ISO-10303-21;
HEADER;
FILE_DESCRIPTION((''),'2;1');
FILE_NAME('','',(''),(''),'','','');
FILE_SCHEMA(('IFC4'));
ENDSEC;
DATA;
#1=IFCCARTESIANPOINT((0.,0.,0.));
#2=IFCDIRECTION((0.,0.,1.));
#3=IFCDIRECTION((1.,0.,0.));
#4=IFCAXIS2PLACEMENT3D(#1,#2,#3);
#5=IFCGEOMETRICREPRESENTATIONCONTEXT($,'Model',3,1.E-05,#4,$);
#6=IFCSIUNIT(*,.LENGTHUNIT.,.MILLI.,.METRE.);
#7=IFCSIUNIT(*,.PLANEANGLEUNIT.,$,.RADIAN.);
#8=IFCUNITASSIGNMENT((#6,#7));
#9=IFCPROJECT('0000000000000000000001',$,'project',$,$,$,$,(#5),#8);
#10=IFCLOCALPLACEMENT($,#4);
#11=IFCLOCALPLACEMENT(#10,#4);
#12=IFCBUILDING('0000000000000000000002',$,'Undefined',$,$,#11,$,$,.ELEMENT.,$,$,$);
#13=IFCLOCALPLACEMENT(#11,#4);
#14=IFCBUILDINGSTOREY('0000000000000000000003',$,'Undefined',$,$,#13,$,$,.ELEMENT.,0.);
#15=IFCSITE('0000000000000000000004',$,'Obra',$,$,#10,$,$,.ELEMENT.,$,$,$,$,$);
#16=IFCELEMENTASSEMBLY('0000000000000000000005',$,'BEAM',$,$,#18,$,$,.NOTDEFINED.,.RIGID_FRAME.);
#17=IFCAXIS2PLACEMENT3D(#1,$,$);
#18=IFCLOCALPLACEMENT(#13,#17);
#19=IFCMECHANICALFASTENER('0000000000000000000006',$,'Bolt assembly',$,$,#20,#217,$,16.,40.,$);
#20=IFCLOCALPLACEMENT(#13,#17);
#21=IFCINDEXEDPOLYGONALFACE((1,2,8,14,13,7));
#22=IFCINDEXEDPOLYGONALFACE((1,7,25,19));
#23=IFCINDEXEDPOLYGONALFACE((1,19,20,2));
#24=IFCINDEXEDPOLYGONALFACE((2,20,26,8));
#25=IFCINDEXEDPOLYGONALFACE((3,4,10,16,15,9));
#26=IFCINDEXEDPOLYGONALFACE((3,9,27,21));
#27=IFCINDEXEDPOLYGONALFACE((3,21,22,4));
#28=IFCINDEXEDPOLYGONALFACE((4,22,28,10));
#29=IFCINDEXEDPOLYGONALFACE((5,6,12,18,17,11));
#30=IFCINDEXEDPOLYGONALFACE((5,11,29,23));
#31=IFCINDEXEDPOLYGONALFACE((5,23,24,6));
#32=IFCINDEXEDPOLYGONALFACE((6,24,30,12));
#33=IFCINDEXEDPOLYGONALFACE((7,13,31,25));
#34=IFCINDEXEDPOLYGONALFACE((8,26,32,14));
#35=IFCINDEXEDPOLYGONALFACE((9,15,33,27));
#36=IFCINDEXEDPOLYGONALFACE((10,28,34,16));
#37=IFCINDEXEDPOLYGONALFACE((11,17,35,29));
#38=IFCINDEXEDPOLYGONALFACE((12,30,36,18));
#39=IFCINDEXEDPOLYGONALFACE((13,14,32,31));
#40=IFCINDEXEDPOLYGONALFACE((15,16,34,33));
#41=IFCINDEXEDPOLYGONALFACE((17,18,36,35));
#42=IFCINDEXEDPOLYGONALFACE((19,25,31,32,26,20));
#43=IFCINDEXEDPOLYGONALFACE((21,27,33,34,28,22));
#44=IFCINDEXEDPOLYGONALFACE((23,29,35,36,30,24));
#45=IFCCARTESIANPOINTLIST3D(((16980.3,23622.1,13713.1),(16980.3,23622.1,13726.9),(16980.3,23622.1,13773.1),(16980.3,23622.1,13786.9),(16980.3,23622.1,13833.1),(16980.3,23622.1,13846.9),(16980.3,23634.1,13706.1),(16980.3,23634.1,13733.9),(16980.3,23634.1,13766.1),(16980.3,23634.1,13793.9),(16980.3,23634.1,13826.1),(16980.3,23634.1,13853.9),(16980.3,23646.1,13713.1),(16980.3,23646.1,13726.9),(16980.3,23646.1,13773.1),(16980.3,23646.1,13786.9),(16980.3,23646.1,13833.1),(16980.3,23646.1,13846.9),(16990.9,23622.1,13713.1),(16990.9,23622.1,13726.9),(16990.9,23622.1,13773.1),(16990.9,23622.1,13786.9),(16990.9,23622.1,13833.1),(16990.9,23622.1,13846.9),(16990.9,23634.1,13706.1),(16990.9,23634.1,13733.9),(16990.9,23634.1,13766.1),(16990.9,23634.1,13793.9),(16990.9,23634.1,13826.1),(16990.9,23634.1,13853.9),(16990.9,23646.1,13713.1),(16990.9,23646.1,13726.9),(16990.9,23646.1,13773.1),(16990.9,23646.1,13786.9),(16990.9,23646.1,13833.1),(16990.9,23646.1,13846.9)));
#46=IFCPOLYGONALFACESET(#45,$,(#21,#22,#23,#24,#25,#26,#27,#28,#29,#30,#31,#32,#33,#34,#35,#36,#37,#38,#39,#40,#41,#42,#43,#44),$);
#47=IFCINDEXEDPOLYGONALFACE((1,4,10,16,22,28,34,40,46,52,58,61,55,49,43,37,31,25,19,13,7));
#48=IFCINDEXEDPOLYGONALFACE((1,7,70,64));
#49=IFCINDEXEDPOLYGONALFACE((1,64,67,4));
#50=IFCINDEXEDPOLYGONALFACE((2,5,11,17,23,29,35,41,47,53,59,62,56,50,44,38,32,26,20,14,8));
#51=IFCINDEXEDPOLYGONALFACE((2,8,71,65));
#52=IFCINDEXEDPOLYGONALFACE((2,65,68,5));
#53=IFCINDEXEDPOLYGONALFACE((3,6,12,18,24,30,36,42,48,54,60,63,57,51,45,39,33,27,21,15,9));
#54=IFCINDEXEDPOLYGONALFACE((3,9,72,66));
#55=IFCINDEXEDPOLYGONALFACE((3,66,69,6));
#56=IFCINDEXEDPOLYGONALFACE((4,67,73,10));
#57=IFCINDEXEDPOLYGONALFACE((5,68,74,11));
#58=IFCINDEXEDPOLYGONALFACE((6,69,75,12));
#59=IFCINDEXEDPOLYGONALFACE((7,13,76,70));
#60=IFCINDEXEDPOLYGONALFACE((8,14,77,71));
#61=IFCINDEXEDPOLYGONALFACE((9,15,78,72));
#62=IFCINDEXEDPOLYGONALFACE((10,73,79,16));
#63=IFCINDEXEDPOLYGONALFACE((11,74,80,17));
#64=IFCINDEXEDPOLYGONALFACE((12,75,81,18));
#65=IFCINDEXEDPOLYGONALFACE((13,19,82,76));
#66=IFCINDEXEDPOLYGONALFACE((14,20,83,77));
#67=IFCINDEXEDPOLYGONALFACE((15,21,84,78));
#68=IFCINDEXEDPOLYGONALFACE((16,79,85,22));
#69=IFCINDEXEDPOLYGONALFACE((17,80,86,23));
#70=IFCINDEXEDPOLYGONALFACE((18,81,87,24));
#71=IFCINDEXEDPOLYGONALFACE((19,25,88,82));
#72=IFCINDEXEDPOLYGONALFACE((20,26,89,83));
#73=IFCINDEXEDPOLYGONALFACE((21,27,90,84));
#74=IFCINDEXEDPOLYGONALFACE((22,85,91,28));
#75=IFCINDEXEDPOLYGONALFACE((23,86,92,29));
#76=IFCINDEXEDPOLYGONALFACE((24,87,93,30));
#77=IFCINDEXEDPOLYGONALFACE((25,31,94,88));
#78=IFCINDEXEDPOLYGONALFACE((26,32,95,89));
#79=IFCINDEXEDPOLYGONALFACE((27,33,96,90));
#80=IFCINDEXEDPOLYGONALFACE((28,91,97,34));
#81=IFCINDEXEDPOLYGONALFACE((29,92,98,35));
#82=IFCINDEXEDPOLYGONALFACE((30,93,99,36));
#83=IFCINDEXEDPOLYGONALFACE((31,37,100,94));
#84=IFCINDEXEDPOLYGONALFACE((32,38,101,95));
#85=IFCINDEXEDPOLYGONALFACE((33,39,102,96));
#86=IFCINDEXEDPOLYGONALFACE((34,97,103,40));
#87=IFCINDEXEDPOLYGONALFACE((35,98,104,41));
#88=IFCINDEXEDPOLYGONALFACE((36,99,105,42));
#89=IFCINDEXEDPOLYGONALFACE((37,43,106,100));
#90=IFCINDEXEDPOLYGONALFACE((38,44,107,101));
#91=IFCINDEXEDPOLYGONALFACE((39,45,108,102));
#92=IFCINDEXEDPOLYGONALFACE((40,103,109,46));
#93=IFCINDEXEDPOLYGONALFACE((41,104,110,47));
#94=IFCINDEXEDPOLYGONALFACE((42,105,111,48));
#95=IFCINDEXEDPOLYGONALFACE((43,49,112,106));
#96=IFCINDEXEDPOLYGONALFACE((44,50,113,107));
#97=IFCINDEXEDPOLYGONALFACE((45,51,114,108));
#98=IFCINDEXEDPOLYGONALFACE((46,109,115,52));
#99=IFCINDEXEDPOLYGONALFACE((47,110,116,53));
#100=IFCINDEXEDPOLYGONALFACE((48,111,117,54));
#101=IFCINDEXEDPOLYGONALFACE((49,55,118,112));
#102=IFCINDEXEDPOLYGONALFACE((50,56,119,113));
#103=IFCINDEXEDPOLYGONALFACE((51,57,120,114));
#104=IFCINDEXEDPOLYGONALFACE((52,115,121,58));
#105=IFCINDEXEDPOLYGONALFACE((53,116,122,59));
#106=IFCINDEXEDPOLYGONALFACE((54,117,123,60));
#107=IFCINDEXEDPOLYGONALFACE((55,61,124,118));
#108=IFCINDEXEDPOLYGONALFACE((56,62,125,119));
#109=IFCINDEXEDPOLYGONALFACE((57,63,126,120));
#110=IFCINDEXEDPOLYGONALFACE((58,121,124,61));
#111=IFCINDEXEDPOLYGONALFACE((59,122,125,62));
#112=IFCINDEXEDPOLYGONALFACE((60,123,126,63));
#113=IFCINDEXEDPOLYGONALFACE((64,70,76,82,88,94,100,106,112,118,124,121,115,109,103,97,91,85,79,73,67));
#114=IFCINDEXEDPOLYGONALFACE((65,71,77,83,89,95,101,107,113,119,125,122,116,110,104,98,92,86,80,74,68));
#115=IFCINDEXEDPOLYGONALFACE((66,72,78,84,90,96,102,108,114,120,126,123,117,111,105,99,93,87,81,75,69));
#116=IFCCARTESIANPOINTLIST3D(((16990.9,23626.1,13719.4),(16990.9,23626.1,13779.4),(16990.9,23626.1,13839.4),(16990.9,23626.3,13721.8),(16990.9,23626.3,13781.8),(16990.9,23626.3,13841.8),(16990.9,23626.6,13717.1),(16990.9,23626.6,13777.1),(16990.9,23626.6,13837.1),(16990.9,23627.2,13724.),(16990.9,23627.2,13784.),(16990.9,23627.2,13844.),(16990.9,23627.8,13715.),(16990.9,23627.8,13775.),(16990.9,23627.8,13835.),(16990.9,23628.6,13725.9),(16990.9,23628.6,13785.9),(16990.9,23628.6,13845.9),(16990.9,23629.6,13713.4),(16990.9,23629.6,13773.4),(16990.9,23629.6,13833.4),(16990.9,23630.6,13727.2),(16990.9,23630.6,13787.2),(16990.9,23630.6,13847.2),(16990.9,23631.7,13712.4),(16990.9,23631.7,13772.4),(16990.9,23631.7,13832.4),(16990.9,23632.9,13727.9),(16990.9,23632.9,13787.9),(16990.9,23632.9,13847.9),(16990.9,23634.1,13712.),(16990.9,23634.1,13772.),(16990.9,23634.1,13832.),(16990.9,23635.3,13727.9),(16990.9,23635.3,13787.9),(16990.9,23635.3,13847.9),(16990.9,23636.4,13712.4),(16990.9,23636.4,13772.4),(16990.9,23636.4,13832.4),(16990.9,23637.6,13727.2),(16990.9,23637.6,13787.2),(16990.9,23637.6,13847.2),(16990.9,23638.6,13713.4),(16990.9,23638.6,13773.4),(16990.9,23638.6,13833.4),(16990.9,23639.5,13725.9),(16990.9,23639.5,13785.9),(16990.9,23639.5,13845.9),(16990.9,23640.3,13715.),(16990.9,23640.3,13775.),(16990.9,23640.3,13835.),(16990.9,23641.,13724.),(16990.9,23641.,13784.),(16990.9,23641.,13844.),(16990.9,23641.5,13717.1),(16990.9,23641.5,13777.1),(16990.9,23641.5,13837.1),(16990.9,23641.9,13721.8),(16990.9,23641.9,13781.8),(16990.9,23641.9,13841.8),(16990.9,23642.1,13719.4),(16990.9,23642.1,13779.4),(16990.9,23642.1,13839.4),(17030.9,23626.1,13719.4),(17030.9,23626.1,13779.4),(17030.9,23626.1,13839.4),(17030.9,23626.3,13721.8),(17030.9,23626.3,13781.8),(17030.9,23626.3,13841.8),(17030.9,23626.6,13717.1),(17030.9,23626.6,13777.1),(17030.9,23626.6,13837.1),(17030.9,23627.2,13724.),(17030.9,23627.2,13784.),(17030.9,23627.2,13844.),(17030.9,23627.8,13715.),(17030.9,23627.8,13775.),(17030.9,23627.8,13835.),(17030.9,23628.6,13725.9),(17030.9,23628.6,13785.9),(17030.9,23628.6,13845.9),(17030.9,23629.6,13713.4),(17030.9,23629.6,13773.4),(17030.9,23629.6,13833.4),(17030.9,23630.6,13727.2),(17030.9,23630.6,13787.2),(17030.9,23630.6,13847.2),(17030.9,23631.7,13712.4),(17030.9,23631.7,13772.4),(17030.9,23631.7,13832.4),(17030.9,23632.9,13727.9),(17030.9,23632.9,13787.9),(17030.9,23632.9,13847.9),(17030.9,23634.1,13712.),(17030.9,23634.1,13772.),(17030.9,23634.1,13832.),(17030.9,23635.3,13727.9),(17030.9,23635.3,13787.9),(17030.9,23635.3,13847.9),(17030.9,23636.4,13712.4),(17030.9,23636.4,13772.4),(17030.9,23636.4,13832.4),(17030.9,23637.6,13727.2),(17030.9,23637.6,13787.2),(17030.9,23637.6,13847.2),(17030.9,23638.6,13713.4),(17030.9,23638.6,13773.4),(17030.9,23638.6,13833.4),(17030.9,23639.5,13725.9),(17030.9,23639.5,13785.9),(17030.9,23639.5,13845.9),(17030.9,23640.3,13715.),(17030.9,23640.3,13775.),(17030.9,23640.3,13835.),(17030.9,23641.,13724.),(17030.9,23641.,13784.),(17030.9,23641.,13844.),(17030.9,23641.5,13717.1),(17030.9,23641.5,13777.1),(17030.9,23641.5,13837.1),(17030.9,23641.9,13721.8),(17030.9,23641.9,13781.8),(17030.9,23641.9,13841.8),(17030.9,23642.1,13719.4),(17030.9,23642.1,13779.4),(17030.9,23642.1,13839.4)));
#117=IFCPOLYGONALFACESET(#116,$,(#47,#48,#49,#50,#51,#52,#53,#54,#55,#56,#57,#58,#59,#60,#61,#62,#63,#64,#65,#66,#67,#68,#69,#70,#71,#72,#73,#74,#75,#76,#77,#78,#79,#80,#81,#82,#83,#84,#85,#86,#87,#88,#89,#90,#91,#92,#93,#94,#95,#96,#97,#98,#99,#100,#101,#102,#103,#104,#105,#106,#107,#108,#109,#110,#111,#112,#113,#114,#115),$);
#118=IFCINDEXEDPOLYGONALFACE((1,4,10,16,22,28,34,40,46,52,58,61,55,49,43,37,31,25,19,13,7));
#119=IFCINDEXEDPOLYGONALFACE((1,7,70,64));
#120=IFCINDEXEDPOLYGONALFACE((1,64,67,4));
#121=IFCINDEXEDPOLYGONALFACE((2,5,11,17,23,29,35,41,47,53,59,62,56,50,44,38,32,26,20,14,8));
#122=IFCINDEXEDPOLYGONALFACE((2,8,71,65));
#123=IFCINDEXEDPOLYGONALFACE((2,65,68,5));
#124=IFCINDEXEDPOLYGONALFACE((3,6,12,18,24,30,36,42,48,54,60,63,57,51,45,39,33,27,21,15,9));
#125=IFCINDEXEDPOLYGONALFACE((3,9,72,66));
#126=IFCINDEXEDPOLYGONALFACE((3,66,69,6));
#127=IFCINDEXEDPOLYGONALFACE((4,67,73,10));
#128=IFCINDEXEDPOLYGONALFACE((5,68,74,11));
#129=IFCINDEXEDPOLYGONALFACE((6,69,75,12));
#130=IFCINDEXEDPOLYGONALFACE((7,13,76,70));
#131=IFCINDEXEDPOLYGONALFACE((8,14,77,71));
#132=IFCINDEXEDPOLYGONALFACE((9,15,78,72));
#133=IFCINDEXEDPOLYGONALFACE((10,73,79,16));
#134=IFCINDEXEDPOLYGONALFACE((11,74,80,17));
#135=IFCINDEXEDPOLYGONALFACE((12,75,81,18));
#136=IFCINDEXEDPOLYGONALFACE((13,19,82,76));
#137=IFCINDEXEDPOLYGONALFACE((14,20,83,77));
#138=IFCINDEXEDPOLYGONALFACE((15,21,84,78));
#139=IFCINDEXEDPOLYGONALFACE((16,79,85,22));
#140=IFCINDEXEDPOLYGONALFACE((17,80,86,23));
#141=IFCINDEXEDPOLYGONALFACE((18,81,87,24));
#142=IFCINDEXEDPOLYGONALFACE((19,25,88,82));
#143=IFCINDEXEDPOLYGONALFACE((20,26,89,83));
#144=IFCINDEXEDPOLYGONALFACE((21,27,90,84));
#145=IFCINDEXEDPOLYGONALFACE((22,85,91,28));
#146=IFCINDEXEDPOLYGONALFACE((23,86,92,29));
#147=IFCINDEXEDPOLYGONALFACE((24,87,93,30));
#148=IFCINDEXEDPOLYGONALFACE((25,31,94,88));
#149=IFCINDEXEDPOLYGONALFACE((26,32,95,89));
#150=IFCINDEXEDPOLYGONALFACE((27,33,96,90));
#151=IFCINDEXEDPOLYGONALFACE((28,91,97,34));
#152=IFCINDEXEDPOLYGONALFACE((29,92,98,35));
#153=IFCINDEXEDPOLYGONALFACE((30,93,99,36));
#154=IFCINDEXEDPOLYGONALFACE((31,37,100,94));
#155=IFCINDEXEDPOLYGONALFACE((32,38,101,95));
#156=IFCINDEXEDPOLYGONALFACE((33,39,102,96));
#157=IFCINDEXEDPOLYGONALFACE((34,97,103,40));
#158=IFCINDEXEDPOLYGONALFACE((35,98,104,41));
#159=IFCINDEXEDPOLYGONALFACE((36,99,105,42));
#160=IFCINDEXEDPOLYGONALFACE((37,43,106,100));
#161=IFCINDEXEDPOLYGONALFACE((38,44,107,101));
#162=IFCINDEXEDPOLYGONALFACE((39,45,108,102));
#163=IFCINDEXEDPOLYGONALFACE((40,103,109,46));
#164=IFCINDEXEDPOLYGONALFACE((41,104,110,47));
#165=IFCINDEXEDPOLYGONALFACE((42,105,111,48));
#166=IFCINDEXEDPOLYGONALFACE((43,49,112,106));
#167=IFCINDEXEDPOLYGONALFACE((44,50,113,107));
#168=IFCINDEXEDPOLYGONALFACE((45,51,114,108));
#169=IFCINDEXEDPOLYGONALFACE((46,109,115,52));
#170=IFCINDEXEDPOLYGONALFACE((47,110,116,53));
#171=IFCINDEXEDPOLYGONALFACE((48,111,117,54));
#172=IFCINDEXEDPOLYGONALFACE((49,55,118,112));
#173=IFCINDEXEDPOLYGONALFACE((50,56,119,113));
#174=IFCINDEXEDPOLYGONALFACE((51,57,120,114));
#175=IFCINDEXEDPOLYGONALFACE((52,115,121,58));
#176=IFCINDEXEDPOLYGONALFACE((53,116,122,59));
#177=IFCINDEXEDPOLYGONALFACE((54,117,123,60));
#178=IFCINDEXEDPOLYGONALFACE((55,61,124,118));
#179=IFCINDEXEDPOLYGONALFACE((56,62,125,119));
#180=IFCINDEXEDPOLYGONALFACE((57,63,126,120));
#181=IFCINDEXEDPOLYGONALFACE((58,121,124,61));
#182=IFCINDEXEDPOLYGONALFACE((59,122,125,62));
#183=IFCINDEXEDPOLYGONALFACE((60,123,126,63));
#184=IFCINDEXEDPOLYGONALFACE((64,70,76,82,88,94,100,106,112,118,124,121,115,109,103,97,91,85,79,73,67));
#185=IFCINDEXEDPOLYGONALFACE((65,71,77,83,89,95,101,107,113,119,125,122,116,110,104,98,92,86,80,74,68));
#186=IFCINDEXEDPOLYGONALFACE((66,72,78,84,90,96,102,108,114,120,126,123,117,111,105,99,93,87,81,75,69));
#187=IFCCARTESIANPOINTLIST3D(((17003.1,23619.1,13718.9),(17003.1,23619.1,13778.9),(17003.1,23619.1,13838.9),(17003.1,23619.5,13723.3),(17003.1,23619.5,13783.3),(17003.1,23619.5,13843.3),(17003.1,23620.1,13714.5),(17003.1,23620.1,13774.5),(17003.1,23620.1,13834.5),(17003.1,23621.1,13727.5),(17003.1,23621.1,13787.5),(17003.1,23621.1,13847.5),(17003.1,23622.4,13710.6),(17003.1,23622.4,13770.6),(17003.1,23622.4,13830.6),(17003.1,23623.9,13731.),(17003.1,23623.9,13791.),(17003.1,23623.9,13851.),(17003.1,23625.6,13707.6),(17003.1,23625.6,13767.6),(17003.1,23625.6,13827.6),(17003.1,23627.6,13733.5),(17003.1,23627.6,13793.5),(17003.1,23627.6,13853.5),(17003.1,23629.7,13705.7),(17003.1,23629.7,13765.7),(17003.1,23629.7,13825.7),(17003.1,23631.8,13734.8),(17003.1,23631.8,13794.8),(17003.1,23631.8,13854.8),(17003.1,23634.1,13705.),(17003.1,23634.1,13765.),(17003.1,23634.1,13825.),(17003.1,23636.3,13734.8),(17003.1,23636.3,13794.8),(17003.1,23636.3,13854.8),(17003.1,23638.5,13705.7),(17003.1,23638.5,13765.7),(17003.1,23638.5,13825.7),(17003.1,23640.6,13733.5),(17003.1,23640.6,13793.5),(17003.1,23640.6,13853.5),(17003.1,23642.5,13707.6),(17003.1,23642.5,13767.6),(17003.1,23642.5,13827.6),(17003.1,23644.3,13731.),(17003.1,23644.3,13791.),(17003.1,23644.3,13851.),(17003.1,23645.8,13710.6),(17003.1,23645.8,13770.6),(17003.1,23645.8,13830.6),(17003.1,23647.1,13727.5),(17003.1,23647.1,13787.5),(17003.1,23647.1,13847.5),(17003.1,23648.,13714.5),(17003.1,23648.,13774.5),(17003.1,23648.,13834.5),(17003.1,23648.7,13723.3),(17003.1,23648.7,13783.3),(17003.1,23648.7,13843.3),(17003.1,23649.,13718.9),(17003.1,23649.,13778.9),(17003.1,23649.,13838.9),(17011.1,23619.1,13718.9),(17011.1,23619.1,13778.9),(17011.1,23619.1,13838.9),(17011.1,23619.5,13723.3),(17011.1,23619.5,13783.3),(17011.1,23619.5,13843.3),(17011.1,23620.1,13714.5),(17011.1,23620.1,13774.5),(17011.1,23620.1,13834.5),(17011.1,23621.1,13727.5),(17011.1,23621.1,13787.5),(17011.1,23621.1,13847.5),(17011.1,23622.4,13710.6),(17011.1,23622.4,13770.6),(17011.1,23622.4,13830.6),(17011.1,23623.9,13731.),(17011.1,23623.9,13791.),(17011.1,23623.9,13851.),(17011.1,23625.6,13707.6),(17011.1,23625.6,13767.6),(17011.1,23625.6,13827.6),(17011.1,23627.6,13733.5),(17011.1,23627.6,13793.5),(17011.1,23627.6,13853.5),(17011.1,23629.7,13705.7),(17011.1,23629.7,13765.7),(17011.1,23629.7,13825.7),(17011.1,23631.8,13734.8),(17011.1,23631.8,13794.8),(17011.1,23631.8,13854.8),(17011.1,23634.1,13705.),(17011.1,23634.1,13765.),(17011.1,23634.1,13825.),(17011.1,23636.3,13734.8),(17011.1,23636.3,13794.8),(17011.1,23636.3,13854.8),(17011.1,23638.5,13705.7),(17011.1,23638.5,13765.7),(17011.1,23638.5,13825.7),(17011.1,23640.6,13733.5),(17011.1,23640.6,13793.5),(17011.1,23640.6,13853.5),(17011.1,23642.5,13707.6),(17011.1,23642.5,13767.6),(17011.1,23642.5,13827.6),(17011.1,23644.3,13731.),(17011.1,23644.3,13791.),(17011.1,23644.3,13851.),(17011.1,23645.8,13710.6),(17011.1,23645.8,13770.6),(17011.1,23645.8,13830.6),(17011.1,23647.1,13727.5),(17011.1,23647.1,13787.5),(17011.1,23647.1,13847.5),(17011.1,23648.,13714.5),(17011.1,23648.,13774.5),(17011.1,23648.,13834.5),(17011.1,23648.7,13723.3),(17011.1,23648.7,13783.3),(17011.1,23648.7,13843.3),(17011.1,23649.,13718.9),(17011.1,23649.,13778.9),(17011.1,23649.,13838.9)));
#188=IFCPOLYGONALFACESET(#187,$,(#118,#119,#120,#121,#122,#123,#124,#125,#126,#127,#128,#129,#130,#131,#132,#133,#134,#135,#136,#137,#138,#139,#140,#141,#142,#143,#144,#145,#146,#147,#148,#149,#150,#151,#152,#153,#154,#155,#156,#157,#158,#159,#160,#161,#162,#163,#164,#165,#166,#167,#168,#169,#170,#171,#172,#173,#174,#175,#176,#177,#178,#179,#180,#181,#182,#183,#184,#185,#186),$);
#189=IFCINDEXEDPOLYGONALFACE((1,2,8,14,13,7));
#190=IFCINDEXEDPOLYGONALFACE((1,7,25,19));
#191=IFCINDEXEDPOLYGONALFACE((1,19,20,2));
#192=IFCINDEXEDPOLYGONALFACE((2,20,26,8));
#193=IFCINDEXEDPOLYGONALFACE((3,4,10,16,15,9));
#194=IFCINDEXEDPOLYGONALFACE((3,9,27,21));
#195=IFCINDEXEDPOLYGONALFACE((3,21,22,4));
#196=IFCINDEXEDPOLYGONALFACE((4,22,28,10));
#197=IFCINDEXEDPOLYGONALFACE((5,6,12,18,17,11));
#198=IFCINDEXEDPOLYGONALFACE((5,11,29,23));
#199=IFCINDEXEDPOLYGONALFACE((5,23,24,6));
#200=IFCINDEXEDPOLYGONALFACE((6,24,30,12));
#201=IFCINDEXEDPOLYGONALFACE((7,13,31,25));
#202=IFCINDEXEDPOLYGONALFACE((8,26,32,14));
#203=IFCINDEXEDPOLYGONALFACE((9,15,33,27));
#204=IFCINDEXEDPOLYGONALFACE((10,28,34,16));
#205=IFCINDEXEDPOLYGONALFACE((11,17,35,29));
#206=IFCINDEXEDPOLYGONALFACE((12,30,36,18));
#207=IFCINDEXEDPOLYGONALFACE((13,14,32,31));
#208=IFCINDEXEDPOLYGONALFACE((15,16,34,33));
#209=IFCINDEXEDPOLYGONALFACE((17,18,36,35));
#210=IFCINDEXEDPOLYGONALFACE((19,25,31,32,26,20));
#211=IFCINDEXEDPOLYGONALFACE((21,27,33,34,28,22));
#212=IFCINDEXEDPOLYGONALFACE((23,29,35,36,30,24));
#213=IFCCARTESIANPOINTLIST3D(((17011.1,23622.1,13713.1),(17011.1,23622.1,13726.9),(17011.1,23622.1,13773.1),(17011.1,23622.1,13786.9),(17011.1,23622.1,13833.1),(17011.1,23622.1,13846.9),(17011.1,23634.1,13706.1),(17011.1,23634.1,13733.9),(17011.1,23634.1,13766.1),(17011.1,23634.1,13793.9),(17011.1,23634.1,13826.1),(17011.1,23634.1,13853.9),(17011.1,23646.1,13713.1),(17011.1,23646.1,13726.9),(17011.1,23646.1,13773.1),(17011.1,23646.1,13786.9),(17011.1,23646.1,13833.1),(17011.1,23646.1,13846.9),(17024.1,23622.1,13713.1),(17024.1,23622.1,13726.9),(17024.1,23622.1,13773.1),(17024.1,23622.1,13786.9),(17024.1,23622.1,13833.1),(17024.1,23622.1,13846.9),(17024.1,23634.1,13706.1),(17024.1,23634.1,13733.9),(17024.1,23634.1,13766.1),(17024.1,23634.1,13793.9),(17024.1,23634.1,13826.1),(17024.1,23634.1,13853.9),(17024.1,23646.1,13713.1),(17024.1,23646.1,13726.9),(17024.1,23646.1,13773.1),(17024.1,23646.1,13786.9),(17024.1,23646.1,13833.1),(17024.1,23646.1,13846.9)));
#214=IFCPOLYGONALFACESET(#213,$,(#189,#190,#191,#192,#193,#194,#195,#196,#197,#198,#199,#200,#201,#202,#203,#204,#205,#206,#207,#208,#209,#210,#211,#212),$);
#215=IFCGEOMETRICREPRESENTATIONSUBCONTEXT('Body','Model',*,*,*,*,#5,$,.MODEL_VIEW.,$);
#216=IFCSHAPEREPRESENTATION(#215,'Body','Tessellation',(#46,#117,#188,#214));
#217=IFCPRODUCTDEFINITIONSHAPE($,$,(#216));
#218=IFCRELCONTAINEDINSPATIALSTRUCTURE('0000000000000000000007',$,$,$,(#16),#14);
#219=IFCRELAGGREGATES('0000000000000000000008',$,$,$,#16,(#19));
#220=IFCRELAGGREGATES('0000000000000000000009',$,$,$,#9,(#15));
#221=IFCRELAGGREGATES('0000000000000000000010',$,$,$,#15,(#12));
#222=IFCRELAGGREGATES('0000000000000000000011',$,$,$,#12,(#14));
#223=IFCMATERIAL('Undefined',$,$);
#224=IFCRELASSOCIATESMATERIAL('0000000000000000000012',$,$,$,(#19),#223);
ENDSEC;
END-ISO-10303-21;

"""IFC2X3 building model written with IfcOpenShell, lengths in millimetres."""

from ifc_helpers import new_model, si_unit, frame, origin_with_axes, origin_2d_with_axis, place, context, subcontext, project, spatial, polyline, circle, outline, extrude, source, transform, mapped, material, element, aggregate, save


model = new_model("IFC2X3")

# Units and contexts
model_context = context("Model", 3, precision=1e-05, world=origin_with_axes())
body_context = subcontext(model_context, "Body", "Model", "MODEL_VIEW")
ifc_project = project(units=[si_unit("LENGTHUNIT", "METRE", prefix="MILLI"), si_unit("PLANEANGLEUNIT", "RADIAN")], contexts=[model_context])

# Site, building, storey
site_placement = place(None, origin_with_axes())
site = spatial("IfcSite", under=ifc_project, at=site_placement, Name="Obra", CompositionType="ELEMENT")
building_placement = place(site_placement, origin_with_axes())
building = spatial("IfcBuilding", under=site, at=building_placement, Name="Undefined", CompositionType="ELEMENT")
storey_placement = place(building_placement, origin_with_axes())
storey = spatial("IfcBuildingStorey", under=building, at=storey_placement, Name="Undefined", CompositionType="ELEMENT", Elevation=0.0)

# Shared definitions
ifc_material_1 = material(Name="Undefined")

# Element assembly, mechanical fastener
assembly_1_placement = place(storey_placement, origin_with_axes())
assembly_1 = element("IfcElementAssembly", 1, at=assembly_1_placement, inside=storey, Name="BEAM", AssemblyPlace="NOTDEFINED", PredefinedType="RIGID_FRAME")
shared_shape_1 = source(origin_with_axes(), body_context, "Body", "SweptSolid", [
    extrude(outline(polyline([(13.9, 0.0), (6.9, 12.0), (-6.9, 12.0), (-13.9, 0.0), (-6.9, -12.0), (6.9, -12.0), (13.9, 0.0)])), frame((0.0, -19.7, 0.0), z_axis=(0.0, 1.0, 0.0), x_axis=(1.0, 0.0, 0.0)), (0.0, 0.0, 1.0), 10.6),
    extrude(circle(Radius=8.0, at=origin_2d_with_axis()), frame((0.0, -9.1, 0.0), z_axis=(0.0, 1.0, 0.0), x_axis=(1.0, 0.0, 0.0)), (0.0, 0.0, 1.0), 40.0),
    extrude(circle(Radius=15.0, at=origin_2d_with_axis()), frame((0.0, 3.1, 0.0), z_axis=(0.0, 1.0, 0.0), x_axis=(1.0, 0.0, 0.0)), (0.0, 0.0, 1.0), 8.0),
    extrude(outline(polyline([(13.9, 0.0), (6.9, 12.0), (-6.9, 12.0), (-13.9, 0.0), (-6.9, -12.0), (6.9, -12.0), (13.9, 0.0)])), frame((0.0, 11.1, 0.0), z_axis=(0.0, 1.0, 0.0), x_axis=(1.0, 0.0, 0.0)), (0.0, 0.0, 1.0), 13.0),
])
mechanical_fastener_1_placement = place(assembly_1_placement, frame((17000.0, 23684.1, 13900.0), z_axis=(0.0, -1.0, 0.0), x_axis=(0.0, 0.0, -1.0)))
mechanical_fastener_1 = element("IfcMechanicalFastener", 2, at=mechanical_fastener_1_placement, material=ifc_material_1, Name="Bolt assembly", NominalDiameter=16.0, NominalLength=40.0, context=body_context, shape_type="MappedRepresentation", body=[
    mapped(shared_shape_1, transform((60.0, 0.0, 50.0))),
    mapped(shared_shape_1, transform((120.0, 0.0, 50.0))),
    mapped(shared_shape_1, transform((180.0, 0.0, 50.0))),
])
aggregate(assembly_1, [mechanical_fastener_1])

save(model, "model.ifc")
